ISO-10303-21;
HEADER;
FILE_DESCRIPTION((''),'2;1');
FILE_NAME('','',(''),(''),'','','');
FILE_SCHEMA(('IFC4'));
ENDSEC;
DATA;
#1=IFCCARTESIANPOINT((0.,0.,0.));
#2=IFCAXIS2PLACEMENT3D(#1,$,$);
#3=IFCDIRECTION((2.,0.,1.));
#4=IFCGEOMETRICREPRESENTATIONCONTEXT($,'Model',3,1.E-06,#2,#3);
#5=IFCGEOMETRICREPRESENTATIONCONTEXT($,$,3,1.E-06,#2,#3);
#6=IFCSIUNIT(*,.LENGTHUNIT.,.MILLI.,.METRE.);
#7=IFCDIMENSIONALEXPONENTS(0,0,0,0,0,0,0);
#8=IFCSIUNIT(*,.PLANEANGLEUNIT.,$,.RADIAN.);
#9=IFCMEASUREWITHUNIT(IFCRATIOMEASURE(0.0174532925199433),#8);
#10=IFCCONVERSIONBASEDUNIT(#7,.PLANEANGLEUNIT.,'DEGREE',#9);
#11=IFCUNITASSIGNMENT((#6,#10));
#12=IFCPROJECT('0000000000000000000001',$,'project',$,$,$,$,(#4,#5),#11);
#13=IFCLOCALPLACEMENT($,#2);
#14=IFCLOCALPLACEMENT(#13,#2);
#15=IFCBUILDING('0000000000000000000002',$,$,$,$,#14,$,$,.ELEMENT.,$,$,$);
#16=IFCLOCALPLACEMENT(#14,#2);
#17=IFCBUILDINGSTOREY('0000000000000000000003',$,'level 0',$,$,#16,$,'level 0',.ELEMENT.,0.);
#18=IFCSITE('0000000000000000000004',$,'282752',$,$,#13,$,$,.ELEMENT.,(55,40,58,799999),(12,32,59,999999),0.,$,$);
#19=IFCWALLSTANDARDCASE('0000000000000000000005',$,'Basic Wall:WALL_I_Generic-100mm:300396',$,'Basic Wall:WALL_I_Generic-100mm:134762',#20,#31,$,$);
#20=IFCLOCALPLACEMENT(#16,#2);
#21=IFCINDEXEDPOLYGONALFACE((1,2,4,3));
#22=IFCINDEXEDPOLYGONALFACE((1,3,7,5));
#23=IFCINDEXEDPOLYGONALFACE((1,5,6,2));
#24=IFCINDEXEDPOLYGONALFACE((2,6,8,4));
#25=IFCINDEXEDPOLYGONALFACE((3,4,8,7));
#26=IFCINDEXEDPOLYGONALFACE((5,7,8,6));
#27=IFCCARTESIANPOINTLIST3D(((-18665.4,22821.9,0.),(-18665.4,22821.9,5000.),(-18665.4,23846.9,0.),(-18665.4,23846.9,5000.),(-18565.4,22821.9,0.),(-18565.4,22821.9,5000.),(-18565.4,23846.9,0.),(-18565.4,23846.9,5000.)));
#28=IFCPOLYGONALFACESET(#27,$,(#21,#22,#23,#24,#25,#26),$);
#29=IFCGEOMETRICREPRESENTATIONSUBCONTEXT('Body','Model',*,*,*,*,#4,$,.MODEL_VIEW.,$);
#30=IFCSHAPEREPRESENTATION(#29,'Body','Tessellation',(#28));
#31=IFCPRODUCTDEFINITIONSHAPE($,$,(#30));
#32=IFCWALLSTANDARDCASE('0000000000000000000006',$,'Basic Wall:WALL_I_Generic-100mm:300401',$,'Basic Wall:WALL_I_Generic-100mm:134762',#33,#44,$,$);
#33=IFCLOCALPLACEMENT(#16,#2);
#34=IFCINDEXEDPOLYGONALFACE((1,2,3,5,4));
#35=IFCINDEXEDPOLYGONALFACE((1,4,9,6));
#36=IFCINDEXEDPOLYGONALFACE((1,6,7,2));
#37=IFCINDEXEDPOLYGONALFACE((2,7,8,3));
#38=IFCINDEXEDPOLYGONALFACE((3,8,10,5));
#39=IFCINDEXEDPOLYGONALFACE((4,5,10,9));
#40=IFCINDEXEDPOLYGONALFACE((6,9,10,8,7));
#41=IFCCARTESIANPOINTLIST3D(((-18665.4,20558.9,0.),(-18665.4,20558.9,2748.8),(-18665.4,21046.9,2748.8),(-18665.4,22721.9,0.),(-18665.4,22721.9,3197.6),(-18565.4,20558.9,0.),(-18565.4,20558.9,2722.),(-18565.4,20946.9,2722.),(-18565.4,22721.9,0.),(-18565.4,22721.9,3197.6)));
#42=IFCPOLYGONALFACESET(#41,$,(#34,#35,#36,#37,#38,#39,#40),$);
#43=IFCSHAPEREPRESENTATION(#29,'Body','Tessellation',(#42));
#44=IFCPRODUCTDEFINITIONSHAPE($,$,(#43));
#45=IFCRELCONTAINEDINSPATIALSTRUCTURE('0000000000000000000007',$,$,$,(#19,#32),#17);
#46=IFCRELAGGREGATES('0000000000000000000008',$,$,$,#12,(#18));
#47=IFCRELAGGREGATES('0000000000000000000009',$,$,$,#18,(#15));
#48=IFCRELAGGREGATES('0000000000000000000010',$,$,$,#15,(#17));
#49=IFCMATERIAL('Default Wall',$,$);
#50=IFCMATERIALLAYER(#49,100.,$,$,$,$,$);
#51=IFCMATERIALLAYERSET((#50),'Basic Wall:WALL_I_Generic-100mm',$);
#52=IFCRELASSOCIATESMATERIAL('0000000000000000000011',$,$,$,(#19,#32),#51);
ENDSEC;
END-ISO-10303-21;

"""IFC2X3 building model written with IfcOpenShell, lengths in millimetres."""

from ifc_helpers import new_model, entity, si_unit, converted_unit, direction, frame, frame_2d, origin, place, context, subcontext, project, spatial, polyline, rectangle, extrude, clip, bounded_halfspace, material, layer, layer_set, layer_usage, element, save


model = new_model("IFC2X3")

# Units and contexts
model_context = context("Model", 3, precision=1e-06, world=origin(), true_north=direction((2.0, 0.0, 1.0)))
context_of_model = context(None, 3, precision=1e-06, world=origin(), true_north=direction((2.0, 0.0, 1.0)))
body_context = subcontext(model_context, "Body", "Model", "MODEL_VIEW")
ifc_project = project(units=[si_unit("LENGTHUNIT", "METRE", prefix="MILLI"), converted_unit("PLANEANGLEUNIT", "DEGREE", entity("IfcRatioMeasure", 0.0174532925199433), si_unit("PLANEANGLEUNIT", "RADIAN"), dimensions=[0, 0, 0, 0, 0, 0, 0])], contexts=[model_context, context_of_model])

# Site, building, storey
site_placement = place(None, origin())
site = spatial("IfcSite", under=ifc_project, at=site_placement, Name="282752", CompositionType="ELEMENT", RefLatitude=(55, 40, 58, 799999), RefLongitude=(12, 32, 59, 999999), RefElevation=0.0)
building_placement = place(site_placement, origin())
building = spatial("IfcBuilding", under=site, at=building_placement, CompositionType="ELEMENT")
storey_placement = place(building_placement, origin())
storey = spatial("IfcBuildingStorey", under=building, at=storey_placement, Name="level 0", LongName="level 0", CompositionType="ELEMENT", Elevation=0.0)

# Shared definitions
ifc_material_1 = material(Name="Default Wall")
ifc_layer_1 = layer(ifc_material_1, 100.0)
ifc_layer_set_1 = layer_set([ifc_layer_1], Name="Basic Wall:WALL_I_Generic-100mm")

# Walls
ifc_layer_usage_1 = layer_usage(ifc_layer_set_1, "AXIS2", "NEGATIVE", 50.0)
wall_1_placement = place(storey_placement, frame((-18615.4, 22821.9, 0.0), z_axis=(0.0, 0.0, 1.0), x_axis=(0.0, 1.0, 0.0)))
element("IfcWallStandardCase", 1, at=wall_1_placement, inside=storey, material=ifc_layer_usage_1, Name="Basic Wall:WALL_I_Generic-100mm:300396", ObjectType="Basic Wall:WALL_I_Generic-100mm:134762", context=body_context, shape_type="SweptSolid", body=[
    extrude(rectangle(XDim=1025.0, YDim=100.0, at=frame_2d((512.5, 0.0), x_axis=(-1.0, 0.0))), origin(), (0.0, 0.0, 1.0), 5000.0),
])
ifc_layer_usage_2 = layer_usage(ifc_layer_set_1, "AXIS2", "NEGATIVE", 50.0)
wall_2_placement = place(storey_placement, frame((-18615.4, 20558.9, 0.0), z_axis=(0.0, 0.0, 1.0), x_axis=(0.0, 1.0, 0.0)))
element("IfcWallStandardCase", 2, at=wall_2_placement, inside=storey, material=ifc_layer_usage_2, Name="Basic Wall:WALL_I_Generic-100mm:300401", ObjectType="Basic Wall:WALL_I_Generic-100mm:134762", context=body_context, shape_type="Clipping", body=[
    clip(clip(extrude(rectangle(XDim=2163.0, YDim=100.0, at=frame_2d((1081.5, 0.0), x_axis=(-1.0, 0.0))), origin(), (0.0, 0.0, 1.0), 4213.2), bounded_halfspace(frame((0.0, -50.0, 2722.0), z_axis=(0.0, -0.258819, 0.965926), x_axis=(1.0, 0.0, 0.0)), False, frame((0.0, -50.0, 2722.0)), polyline([(0.0, 0.0), (388.0, 0.0), (488.0, 100.0), (0.0, 100.0), (0.0, 0.0)]))), bounded_halfspace(frame((388.0, -50.0, 2722.0), z_axis=(-0.258819, 0.0, 0.965926), x_axis=(0.0, -1.0, 0.0)), False, frame((388.0, -50.0, 2722.0)), polyline([(0.0, 0.0), (1775.0, 0.0), (1775.0, 100.0), (100.0, 100.0), (0.0, 0.0)]))),
])

save(model, "model.ifc")
